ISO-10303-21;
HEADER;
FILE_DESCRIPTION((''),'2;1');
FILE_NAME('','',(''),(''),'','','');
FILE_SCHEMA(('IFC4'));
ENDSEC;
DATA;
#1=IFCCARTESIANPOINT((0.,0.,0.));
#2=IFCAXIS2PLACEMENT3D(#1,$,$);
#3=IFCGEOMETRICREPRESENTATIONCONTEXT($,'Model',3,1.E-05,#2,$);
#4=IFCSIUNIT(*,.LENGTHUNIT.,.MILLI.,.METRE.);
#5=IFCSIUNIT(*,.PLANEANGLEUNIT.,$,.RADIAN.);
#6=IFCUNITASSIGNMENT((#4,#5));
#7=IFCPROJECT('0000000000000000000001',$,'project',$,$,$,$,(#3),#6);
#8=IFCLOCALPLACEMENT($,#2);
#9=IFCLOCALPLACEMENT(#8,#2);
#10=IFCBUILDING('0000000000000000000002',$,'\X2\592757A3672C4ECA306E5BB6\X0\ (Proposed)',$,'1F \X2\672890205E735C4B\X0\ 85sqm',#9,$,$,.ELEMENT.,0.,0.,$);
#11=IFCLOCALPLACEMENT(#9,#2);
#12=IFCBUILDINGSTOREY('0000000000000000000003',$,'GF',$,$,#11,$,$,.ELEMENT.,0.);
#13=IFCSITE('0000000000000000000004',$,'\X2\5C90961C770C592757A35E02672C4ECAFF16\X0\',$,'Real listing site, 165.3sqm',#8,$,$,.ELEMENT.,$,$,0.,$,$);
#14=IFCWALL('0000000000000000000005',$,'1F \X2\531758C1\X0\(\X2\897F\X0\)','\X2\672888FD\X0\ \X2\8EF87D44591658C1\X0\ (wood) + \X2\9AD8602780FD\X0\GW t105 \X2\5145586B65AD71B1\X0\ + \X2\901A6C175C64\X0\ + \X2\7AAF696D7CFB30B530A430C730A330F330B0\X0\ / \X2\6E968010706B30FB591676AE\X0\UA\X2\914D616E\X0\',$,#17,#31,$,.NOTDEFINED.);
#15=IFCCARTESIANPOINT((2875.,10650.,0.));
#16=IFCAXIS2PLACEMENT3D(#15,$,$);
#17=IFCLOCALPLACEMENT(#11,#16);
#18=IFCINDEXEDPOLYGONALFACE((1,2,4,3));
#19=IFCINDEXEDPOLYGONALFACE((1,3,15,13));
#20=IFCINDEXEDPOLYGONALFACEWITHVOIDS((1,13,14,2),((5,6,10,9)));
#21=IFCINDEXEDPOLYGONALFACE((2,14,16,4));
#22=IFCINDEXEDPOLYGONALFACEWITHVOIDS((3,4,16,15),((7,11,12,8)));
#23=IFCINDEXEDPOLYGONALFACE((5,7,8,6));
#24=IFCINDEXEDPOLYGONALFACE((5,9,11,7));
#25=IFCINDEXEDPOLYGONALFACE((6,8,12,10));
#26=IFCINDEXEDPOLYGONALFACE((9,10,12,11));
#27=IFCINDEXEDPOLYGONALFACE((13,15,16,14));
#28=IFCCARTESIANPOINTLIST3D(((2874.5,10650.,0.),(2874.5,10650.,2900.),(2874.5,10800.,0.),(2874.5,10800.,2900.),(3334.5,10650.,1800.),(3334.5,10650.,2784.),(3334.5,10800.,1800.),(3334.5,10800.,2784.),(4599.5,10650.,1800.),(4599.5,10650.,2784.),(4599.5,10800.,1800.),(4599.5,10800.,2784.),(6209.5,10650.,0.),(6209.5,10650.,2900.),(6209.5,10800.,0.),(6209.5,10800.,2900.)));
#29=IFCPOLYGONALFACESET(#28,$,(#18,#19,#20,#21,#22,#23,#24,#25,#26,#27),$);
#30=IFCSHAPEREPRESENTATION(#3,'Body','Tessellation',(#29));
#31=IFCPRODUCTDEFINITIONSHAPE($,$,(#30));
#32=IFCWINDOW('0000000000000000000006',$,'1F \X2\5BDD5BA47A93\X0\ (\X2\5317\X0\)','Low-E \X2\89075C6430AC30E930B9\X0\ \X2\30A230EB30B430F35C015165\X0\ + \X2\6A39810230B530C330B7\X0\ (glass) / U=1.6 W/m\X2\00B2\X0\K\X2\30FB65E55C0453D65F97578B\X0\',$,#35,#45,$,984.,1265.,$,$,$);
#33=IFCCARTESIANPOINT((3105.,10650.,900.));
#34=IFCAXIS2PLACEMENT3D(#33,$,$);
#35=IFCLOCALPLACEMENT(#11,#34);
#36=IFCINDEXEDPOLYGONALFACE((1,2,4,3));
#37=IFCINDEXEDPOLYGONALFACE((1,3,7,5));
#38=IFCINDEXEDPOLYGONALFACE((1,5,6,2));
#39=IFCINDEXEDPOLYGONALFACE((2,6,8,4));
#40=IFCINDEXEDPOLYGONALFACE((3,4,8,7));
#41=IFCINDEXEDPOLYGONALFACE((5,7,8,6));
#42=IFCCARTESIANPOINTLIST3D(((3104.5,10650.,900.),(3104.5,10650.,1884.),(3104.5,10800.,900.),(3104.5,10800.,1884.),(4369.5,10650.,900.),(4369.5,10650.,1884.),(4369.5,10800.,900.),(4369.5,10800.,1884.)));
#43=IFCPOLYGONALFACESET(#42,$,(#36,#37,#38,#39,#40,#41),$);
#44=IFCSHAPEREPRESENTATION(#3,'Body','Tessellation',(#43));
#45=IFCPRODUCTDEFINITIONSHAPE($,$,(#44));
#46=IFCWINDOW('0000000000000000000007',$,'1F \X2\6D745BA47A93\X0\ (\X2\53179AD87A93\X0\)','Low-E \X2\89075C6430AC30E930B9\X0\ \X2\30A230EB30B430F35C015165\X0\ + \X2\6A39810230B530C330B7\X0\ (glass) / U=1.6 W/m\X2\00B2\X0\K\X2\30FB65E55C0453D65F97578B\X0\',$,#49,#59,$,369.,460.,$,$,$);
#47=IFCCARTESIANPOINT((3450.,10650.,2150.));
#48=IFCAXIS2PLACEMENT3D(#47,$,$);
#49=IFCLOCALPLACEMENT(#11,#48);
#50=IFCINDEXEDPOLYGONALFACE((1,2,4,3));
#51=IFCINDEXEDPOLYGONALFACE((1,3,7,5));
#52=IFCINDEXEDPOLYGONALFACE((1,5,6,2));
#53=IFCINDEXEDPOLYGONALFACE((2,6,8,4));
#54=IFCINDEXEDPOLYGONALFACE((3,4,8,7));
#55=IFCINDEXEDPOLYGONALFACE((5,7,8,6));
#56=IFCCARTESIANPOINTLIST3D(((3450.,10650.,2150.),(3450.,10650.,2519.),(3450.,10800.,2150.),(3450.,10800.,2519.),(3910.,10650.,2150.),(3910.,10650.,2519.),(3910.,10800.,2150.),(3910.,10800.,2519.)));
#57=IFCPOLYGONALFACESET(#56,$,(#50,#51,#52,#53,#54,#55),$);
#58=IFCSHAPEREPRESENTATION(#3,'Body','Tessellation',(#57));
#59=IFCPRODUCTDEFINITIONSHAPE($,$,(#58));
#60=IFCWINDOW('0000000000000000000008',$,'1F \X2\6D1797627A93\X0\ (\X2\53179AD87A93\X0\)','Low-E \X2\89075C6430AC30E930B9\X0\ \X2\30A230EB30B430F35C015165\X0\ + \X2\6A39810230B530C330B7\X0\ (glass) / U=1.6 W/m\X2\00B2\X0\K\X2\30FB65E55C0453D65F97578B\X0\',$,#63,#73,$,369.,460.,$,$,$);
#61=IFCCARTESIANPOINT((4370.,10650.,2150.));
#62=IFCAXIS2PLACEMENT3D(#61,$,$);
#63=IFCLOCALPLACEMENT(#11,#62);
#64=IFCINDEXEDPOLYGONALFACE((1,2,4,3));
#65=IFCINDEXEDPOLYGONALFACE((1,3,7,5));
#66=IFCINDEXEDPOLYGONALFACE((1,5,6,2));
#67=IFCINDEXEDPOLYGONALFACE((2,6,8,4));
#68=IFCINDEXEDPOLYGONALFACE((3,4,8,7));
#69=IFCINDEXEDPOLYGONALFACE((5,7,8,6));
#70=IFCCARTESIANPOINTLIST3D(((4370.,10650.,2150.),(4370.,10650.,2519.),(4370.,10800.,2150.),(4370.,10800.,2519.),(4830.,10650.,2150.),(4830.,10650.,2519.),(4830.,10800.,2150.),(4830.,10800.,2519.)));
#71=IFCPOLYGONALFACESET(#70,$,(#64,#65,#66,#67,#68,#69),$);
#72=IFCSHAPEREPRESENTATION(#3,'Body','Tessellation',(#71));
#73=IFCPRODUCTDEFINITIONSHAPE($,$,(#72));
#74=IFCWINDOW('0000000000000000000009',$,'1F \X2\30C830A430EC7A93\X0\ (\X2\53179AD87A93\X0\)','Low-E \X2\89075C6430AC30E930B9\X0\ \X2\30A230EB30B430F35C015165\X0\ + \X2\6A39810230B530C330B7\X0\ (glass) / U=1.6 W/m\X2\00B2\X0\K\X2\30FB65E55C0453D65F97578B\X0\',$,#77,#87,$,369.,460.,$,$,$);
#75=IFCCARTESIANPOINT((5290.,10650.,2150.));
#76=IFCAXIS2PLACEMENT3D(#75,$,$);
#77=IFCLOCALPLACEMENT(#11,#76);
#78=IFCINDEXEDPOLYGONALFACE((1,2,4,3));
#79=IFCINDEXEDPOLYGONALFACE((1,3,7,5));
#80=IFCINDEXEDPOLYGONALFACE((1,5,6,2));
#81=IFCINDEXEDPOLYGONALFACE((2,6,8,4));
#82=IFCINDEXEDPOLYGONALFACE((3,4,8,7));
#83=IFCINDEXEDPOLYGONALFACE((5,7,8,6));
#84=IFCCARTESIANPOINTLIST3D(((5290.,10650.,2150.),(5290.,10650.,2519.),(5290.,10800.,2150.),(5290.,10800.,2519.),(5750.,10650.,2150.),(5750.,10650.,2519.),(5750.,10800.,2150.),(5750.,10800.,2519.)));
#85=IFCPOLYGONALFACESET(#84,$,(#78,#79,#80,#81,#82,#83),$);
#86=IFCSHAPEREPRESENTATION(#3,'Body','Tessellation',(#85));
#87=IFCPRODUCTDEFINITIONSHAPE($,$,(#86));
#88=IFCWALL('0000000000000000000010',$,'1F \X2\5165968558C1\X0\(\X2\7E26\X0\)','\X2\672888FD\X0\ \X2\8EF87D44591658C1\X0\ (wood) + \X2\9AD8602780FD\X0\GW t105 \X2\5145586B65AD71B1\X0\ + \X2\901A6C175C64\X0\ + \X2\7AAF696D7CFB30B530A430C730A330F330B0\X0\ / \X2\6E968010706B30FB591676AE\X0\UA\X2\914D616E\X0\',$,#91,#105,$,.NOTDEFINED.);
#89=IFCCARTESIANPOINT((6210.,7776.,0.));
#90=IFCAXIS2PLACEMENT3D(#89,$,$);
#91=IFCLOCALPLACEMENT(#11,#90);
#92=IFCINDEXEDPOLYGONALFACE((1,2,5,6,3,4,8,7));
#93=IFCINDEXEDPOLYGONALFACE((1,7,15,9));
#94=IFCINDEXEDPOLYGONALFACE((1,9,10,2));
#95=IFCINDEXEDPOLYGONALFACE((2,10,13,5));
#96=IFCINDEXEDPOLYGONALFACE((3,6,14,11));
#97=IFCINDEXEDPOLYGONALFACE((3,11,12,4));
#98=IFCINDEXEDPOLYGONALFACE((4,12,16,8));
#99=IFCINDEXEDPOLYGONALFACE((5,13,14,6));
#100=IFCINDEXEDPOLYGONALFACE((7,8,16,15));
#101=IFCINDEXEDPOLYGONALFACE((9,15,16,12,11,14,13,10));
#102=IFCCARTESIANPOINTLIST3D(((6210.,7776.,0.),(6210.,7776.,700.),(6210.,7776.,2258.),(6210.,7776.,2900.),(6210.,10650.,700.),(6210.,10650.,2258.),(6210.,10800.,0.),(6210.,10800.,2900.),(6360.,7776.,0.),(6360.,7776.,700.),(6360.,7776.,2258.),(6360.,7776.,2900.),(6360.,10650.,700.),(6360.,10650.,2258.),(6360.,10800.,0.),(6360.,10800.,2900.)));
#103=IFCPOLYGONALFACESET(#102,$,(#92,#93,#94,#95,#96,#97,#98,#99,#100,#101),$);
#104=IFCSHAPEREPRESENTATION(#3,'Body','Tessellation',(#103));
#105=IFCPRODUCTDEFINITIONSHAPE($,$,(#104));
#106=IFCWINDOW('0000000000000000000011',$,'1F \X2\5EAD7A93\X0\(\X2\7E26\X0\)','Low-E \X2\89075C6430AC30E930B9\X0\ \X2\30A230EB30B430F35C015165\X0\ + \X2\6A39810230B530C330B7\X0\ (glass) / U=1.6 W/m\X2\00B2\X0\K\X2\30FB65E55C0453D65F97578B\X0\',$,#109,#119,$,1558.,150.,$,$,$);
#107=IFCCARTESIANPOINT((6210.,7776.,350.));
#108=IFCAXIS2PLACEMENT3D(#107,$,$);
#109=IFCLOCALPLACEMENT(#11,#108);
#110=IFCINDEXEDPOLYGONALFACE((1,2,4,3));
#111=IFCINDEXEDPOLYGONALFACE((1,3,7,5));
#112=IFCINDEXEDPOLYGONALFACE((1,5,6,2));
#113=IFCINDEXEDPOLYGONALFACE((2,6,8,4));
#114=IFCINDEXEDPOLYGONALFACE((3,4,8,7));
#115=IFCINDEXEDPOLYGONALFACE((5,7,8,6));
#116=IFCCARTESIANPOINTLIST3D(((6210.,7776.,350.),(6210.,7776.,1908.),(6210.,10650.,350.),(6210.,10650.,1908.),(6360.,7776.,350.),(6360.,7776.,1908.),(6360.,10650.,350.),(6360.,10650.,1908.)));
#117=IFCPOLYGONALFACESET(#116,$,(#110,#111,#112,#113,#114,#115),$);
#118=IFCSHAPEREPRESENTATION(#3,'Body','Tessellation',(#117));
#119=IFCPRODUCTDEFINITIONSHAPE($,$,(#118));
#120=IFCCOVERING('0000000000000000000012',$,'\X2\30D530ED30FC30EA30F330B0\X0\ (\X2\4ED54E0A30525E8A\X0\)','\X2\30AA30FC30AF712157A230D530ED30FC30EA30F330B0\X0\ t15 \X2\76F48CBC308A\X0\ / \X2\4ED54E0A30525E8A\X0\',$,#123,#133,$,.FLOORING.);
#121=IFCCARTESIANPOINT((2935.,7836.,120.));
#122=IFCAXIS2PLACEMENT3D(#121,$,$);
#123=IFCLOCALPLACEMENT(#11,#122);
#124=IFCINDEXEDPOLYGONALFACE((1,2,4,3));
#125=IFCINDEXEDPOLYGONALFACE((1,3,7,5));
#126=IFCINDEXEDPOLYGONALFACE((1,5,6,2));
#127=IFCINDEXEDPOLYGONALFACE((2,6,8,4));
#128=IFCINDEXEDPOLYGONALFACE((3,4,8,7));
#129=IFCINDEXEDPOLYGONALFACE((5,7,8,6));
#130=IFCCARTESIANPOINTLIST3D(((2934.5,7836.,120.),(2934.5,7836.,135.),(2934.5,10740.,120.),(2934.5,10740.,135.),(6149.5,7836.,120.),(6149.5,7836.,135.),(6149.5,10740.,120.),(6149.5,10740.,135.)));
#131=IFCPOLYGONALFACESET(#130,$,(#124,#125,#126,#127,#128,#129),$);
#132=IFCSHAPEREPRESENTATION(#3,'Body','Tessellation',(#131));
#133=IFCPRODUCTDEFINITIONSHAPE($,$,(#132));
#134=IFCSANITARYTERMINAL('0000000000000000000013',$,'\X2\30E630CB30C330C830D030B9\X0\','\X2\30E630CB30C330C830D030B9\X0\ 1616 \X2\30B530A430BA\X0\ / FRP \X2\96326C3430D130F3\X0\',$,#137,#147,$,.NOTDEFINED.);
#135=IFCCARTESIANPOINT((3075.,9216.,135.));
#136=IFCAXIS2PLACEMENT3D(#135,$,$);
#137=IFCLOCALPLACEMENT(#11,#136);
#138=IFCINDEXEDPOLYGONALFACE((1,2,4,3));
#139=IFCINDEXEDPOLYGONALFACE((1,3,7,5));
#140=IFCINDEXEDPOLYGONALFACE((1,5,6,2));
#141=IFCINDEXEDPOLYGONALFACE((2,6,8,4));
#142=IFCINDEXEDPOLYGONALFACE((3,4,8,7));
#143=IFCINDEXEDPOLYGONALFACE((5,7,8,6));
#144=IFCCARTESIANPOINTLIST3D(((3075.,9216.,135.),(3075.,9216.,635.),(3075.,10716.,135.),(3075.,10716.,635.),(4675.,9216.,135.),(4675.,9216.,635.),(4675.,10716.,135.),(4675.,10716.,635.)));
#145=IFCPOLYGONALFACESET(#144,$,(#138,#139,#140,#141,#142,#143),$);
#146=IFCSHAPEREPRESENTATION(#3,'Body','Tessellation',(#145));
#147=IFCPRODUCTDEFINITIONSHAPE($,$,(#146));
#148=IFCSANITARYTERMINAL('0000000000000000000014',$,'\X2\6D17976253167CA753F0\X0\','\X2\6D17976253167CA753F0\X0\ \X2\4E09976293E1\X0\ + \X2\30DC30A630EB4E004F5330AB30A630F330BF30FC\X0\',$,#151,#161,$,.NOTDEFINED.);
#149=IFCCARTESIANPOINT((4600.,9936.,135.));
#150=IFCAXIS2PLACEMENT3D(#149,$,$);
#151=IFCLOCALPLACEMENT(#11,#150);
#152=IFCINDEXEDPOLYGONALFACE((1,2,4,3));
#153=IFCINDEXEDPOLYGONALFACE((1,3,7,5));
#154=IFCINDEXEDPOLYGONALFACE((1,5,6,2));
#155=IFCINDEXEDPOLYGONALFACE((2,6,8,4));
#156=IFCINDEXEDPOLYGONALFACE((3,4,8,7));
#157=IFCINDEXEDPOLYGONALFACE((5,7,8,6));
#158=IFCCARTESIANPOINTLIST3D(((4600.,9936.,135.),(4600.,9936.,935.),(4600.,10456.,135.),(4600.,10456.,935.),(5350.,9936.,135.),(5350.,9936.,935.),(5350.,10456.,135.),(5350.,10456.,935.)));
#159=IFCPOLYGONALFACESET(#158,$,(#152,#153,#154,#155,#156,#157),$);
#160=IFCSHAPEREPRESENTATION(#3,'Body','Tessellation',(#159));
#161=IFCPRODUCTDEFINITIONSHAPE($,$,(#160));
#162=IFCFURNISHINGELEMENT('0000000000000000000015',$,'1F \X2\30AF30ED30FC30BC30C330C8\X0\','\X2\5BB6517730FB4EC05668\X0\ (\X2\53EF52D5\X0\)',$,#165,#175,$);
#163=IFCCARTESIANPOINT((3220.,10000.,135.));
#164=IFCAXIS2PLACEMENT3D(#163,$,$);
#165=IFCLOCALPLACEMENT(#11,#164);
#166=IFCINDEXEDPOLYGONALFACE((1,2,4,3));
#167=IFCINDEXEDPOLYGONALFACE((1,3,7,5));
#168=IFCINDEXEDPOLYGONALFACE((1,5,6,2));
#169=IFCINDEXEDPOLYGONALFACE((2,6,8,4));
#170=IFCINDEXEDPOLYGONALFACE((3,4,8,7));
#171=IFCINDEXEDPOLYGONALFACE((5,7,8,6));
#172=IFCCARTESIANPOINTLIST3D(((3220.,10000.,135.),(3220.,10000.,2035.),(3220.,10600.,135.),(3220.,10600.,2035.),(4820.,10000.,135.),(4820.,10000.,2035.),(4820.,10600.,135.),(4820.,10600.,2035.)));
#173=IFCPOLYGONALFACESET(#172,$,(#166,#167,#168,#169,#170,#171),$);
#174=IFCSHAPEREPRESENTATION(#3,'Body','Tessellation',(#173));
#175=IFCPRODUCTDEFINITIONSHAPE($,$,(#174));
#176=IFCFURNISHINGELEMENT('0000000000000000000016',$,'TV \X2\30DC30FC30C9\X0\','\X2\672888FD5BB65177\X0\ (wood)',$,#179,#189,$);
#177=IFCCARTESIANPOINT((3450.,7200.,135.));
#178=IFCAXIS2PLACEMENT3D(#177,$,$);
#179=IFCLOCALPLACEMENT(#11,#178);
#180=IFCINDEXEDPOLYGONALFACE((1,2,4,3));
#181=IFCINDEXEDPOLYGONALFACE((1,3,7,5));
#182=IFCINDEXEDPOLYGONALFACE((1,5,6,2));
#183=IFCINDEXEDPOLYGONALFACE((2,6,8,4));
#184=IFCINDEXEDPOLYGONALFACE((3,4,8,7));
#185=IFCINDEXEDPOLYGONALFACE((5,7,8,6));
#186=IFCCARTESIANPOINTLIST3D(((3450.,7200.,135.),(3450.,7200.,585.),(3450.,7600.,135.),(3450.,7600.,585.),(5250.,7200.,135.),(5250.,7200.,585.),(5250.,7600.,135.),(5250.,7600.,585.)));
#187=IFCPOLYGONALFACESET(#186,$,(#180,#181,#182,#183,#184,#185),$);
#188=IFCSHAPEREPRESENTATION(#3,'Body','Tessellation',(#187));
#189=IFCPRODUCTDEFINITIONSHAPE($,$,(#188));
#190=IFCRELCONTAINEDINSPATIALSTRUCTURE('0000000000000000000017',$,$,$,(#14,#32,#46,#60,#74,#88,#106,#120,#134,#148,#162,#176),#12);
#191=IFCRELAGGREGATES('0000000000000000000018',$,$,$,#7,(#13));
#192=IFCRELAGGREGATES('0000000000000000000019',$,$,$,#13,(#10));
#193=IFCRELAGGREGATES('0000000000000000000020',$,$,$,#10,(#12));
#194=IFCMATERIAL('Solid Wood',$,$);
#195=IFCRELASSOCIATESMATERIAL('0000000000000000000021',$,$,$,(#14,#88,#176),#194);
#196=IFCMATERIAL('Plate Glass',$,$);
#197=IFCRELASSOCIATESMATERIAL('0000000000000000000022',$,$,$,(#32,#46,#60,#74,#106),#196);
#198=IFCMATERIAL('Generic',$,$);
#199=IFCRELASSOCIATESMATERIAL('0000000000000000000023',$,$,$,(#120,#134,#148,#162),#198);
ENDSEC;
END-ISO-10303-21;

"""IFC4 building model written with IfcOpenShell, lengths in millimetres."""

from ifc_helpers import new_model, si_unit, frame, frame_2d, origin, place, context, project, spatial, rectangle, extrude, material, element, fill, save


model = new_model("IFC4")

# Units and contexts
model_context = context("Model", 3, precision=1e-05, world=origin())
ifc_project = project(units=[si_unit("LENGTHUNIT", "METRE", prefix="MILLI"), si_unit("PLANEANGLEUNIT", "RADIAN")], contexts=[model_context])

# Site, building, storey
site_placement = place(None, origin())
site = spatial("IfcSite", under=ifc_project, at=site_placement, Name="岐阜県大垣市本今６", ObjectType="Real listing site, 165.3sqm", CompositionType="ELEMENT", RefElevation=0.0)
building_placement = place(site_placement, origin())
building = spatial("IfcBuilding", under=site, at=building_placement, Name="大垣本今の家 (Proposed)", ObjectType="1F 木造平屋 85sqm", CompositionType="ELEMENT", ElevationOfRefHeight=0.0, ElevationOfTerrain=0.0)
storey_placement = place(building_placement, origin())
storey = spatial("IfcBuildingStorey", under=building, at=storey_placement, Name="GF", CompositionType="ELEMENT", Elevation=0.0)

# Shared definitions
ifc_material_1 = material(Name="Solid Wood")

# Wall, openings, windows
wall_1_placement = place(storey_placement, frame((2875.0, 10650.0, 0.0)))
wall_1 = element("IfcWall", 1, at=wall_1_placement, inside=storey, material=ifc_material_1, Name="1F 北壁(西)", Description="木製 軸組外壁 (wood) + 高性能GW t105 充填断熱 + 通気層 + 窯業系サイディング / 準耐火・外皮UA配慮", PredefinedType="NOTDEFINED", context=model_context, shape_type="SweptSolid", body=[
    extrude(rectangle(XDim=3335.0, YDim=150.0, at=frame_2d((1667.0, 75.0))), frame((2875.0, 10650.0, 0.0)), (0.0, 0.0, 1.0), 2900.0),
])
opening_1_placement = place(storey_placement, frame((3105.0, 10650.0, 900.0)))
opening_1 = element("IfcOpeningElement", 2, at=opening_1_placement, cuts=wall_1, PredefinedType="NOTDEFINED", context=model_context, shape_type="SweptSolid", body=[
    extrude(rectangle(XDim=1265.0, YDim=150.0, at=frame_2d((632.0, 75.0))), frame((3105.0, 10650.0, 900.0)), (0.0, 0.0, 1.0), 984.0),
])
opening_2_placement = place(storey_placement, frame((3450.0, 10650.0, 2150.0)))
opening_2 = element("IfcOpeningElement", 3, at=opening_2_placement, cuts=wall_1, PredefinedType="NOTDEFINED", context=model_context, shape_type="SweptSolid", body=[
    extrude(rectangle(XDim=460.0, YDim=150.0, at=frame_2d((230.0, 75.0))), frame((3450.0, 10650.0, 2150.0)), (0.0, 0.0, 1.0), 369.0),
])
opening_3_placement = place(storey_placement, frame((4370.0, 10650.0, 2150.0)))
opening_3 = element("IfcOpeningElement", 4, at=opening_3_placement, cuts=wall_1, PredefinedType="NOTDEFINED", context=model_context, shape_type="SweptSolid", body=[
    extrude(rectangle(XDim=460.0, YDim=150.0, at=frame_2d((230.0, 75.0))), frame((4370.0, 10650.0, 2150.0)), (0.0, 0.0, 1.0), 369.0),
])
opening_4_placement = place(storey_placement, frame((5290.0, 10650.0, 2150.0)))
opening_4 = element("IfcOpeningElement", 5, at=opening_4_placement, cuts=wall_1, PredefinedType="NOTDEFINED", context=model_context, shape_type="SweptSolid", body=[
    extrude(rectangle(XDim=460.0, YDim=150.0, at=frame_2d((230.0, 75.0))), frame((5290.0, 10650.0, 2150.0)), (0.0, 0.0, 1.0), 369.0),
])
ifc_material_2 = material(Name="Plate Glass")
window_1_placement = place(storey_placement, frame((3105.0, 10650.0, 900.0)))
window_1 = element("IfcWindow", 6, at=window_1_placement, inside=storey, material=ifc_material_2, Name="1F 寝室窓 (北)", Description="Low-E 複層ガラス アルゴン封入 + 樹脂サッシ (glass) / U=1.6 W/m²K・日射取得型", OverallHeight=984.0, OverallWidth=1265.0, context=model_context, shape_type="SweptSolid", body=[
    extrude(rectangle(XDim=1265.0, YDim=150.0, at=frame_2d((632.0, 75.0))), frame((3105.0, 10650.0, 900.0)), (0.0, 0.0, 1.0), 984.0),
])
fill(opening_1, window_1)
window_2_placement = place(storey_placement, frame((3450.0, 10650.0, 2150.0)))
window_2 = element("IfcWindow", 7, at=window_2_placement, inside=storey, material=ifc_material_2, Name="1F 浴室窓 (北高窓)", Description="Low-E 複層ガラス アルゴン封入 + 樹脂サッシ (glass) / U=1.6 W/m²K・日射取得型", OverallHeight=369.0, OverallWidth=460.0, context=model_context, shape_type="SweptSolid", body=[
    extrude(rectangle(XDim=460.0, YDim=150.0, at=frame_2d((230.0, 75.0))), frame((3450.0, 10650.0, 2150.0)), (0.0, 0.0, 1.0), 369.0),
])
fill(opening_2, window_2)
window_3_placement = place(storey_placement, frame((4370.0, 10650.0, 2150.0)))
window_3 = element("IfcWindow", 8, at=window_3_placement, inside=storey, material=ifc_material_2, Name="1F 洗面窓 (北高窓)", Description="Low-E 複層ガラス アルゴン封入 + 樹脂サッシ (glass) / U=1.6 W/m²K・日射取得型", OverallHeight=369.0, OverallWidth=460.0, context=model_context, shape_type="SweptSolid", body=[
    extrude(rectangle(XDim=460.0, YDim=150.0, at=frame_2d((230.0, 75.0))), frame((4370.0, 10650.0, 2150.0)), (0.0, 0.0, 1.0), 369.0),
])
fill(opening_3, window_3)
window_4_placement = place(storey_placement, frame((5290.0, 10650.0, 2150.0)))
window_4 = element("IfcWindow", 9, at=window_4_placement, inside=storey, material=ifc_material_2, Name="1F トイレ窓 (北高窓)", Description="Low-E 複層ガラス アルゴン封入 + 樹脂サッシ (glass) / U=1.6 W/m²K・日射取得型", OverallHeight=369.0, OverallWidth=460.0, context=model_context, shape_type="SweptSolid", body=[
    extrude(rectangle(XDim=460.0, YDim=150.0, at=frame_2d((230.0, 75.0))), frame((5290.0, 10650.0, 2150.0)), (0.0, 0.0, 1.0), 369.0),
])
fill(opening_4, window_4)

# Wall, opening, window
wall_2_placement = place(storey_placement, frame((6210.0, 7776.0, 0.0)))
wall_2 = element("IfcWall", 10, at=wall_2_placement, inside=storey, material=ifc_material_1, Name="1F 入隅壁(縦)", Description="木製 軸組外壁 (wood) + 高性能GW t105 充填断熱 + 通気層 + 窯業系サイディング / 準耐火・外皮UA配慮", PredefinedType="NOTDEFINED", context=model_context, shape_type="SweptSolid", body=[
    extrude(rectangle(XDim=150.0, YDim=3024.0, at=frame_2d((75.0, 1512.0))), frame((6210.0, 7776.0, 0.0)), (0.0, 0.0, 1.0), 2900.0),
])
opening_5_placement = place(storey_placement, frame((6210.0, 7776.0, 350.0)))
opening_5 = element("IfcOpeningElement", 11, at=opening_5_placement, cuts=wall_2, PredefinedType="NOTDEFINED", context=model_context, shape_type="SweptSolid", body=[
    extrude(rectangle(XDim=150.0, YDim=2874.0, at=frame_2d((75.0, 1437.0))), frame((6210.0, 7776.0, 350.0)), (0.0, 0.0, 1.0), 1558.0),
])
window_5_placement = place(storey_placement, frame((6210.0, 7776.0, 350.0)))
window_5 = element("IfcWindow", 12, at=window_5_placement, inside=storey, material=ifc_material_2, Name="1F 庭窓(縦)", Description="Low-E 複層ガラス アルゴン封入 + 樹脂サッシ (glass) / U=1.6 W/m²K・日射取得型", OverallHeight=1558.0, OverallWidth=150.0, context=model_context, shape_type="SweptSolid", body=[
    extrude(rectangle(XDim=150.0, YDim=2874.0, at=frame_2d((75.0, 1437.0))), frame((6210.0, 7776.0, 350.0)), (0.0, 0.0, 1.0), 1558.0),
])
fill(opening_5, window_5)

# Covering
ifc_material_3 = material(Name="Generic")
covering_placement = place(storey_placement, frame((2935.0, 7836.0, 120.0)))
element("IfcCovering", 13, at=covering_placement, inside=storey, material=ifc_material_3, Name="フローリング (仕上げ床)", Description="オーク無垢フローリング t15 直貼り / 仕上げ床", PredefinedType="FLOORING", context=model_context, shape_type="SweptSolid", body=[
    extrude(rectangle(XDim=3215.0, YDim=2904.0, at=frame_2d((1607.0, 1452.0))), frame((2935.0, 7836.0, 120.0)), (0.0, 0.0, 1.0), 15.0),
])

# Sanitary terminals
sanitary_terminal_1_placement = place(storey_placement, frame((3075.0, 9216.0, 135.0)))
element("IfcSanitaryTerminal", 14, at=sanitary_terminal_1_placement, inside=storey, material=ifc_material_3, Name="ユニットバス", Description="ユニットバス 1616 サイズ / FRP 防水パン", PredefinedType="NOTDEFINED", context=model_context, shape_type="SweptSolid", body=[
    extrude(rectangle(XDim=1600.0, YDim=1500.0, at=frame_2d((800.0, 750.0))), frame((3075.0, 9216.0, 135.0)), (0.0, 0.0, 1.0), 500.0),
])
sanitary_terminal_2_placement = place(storey_placement, frame((4600.0, 9936.0, 135.0)))
element("IfcSanitaryTerminal", 15, at=sanitary_terminal_2_placement, inside=storey, material=ifc_material_3, Name="洗面化粧台", Description="洗面化粧台 三面鏡 + ボウル一体カウンター", PredefinedType="NOTDEFINED", context=model_context, shape_type="SweptSolid", body=[
    extrude(rectangle(XDim=750.0, YDim=520.0, at=frame_2d((375.0, 260.0))), frame((4600.0, 9936.0, 135.0)), (0.0, 0.0, 1.0), 800.0),
])

# Furnishing elements
furnishing_1_placement = place(storey_placement, frame((3220.0, 10000.0, 135.0)))
element("IfcFurnishingElement", 16, at=furnishing_1_placement, inside=storey, material=ifc_material_3, Name="1F クローゼット", Description="家具・什器 (可動)", context=model_context, shape_type="SweptSolid", body=[
    extrude(rectangle(XDim=1600.0, YDim=600.0, at=frame_2d((800.0, 300.0))), frame((3220.0, 10000.0, 135.0)), (0.0, 0.0, 1.0), 1900.0),
])
furnishing_2_placement = place(storey_placement, frame((3450.0, 7200.0, 135.0)))
element("IfcFurnishingElement", 17, at=furnishing_2_placement, inside=storey, material=ifc_material_1, Name="TV ボード", Description="木製家具 (wood)", context=model_context, shape_type="SweptSolid", body=[
    extrude(rectangle(XDim=1800.0, YDim=400.0, at=frame_2d((900.0, 200.0))), frame((3450.0, 7200.0, 135.0)), (0.0, 0.0, 1.0), 450.0),
])

save(model, "model.ifc")
